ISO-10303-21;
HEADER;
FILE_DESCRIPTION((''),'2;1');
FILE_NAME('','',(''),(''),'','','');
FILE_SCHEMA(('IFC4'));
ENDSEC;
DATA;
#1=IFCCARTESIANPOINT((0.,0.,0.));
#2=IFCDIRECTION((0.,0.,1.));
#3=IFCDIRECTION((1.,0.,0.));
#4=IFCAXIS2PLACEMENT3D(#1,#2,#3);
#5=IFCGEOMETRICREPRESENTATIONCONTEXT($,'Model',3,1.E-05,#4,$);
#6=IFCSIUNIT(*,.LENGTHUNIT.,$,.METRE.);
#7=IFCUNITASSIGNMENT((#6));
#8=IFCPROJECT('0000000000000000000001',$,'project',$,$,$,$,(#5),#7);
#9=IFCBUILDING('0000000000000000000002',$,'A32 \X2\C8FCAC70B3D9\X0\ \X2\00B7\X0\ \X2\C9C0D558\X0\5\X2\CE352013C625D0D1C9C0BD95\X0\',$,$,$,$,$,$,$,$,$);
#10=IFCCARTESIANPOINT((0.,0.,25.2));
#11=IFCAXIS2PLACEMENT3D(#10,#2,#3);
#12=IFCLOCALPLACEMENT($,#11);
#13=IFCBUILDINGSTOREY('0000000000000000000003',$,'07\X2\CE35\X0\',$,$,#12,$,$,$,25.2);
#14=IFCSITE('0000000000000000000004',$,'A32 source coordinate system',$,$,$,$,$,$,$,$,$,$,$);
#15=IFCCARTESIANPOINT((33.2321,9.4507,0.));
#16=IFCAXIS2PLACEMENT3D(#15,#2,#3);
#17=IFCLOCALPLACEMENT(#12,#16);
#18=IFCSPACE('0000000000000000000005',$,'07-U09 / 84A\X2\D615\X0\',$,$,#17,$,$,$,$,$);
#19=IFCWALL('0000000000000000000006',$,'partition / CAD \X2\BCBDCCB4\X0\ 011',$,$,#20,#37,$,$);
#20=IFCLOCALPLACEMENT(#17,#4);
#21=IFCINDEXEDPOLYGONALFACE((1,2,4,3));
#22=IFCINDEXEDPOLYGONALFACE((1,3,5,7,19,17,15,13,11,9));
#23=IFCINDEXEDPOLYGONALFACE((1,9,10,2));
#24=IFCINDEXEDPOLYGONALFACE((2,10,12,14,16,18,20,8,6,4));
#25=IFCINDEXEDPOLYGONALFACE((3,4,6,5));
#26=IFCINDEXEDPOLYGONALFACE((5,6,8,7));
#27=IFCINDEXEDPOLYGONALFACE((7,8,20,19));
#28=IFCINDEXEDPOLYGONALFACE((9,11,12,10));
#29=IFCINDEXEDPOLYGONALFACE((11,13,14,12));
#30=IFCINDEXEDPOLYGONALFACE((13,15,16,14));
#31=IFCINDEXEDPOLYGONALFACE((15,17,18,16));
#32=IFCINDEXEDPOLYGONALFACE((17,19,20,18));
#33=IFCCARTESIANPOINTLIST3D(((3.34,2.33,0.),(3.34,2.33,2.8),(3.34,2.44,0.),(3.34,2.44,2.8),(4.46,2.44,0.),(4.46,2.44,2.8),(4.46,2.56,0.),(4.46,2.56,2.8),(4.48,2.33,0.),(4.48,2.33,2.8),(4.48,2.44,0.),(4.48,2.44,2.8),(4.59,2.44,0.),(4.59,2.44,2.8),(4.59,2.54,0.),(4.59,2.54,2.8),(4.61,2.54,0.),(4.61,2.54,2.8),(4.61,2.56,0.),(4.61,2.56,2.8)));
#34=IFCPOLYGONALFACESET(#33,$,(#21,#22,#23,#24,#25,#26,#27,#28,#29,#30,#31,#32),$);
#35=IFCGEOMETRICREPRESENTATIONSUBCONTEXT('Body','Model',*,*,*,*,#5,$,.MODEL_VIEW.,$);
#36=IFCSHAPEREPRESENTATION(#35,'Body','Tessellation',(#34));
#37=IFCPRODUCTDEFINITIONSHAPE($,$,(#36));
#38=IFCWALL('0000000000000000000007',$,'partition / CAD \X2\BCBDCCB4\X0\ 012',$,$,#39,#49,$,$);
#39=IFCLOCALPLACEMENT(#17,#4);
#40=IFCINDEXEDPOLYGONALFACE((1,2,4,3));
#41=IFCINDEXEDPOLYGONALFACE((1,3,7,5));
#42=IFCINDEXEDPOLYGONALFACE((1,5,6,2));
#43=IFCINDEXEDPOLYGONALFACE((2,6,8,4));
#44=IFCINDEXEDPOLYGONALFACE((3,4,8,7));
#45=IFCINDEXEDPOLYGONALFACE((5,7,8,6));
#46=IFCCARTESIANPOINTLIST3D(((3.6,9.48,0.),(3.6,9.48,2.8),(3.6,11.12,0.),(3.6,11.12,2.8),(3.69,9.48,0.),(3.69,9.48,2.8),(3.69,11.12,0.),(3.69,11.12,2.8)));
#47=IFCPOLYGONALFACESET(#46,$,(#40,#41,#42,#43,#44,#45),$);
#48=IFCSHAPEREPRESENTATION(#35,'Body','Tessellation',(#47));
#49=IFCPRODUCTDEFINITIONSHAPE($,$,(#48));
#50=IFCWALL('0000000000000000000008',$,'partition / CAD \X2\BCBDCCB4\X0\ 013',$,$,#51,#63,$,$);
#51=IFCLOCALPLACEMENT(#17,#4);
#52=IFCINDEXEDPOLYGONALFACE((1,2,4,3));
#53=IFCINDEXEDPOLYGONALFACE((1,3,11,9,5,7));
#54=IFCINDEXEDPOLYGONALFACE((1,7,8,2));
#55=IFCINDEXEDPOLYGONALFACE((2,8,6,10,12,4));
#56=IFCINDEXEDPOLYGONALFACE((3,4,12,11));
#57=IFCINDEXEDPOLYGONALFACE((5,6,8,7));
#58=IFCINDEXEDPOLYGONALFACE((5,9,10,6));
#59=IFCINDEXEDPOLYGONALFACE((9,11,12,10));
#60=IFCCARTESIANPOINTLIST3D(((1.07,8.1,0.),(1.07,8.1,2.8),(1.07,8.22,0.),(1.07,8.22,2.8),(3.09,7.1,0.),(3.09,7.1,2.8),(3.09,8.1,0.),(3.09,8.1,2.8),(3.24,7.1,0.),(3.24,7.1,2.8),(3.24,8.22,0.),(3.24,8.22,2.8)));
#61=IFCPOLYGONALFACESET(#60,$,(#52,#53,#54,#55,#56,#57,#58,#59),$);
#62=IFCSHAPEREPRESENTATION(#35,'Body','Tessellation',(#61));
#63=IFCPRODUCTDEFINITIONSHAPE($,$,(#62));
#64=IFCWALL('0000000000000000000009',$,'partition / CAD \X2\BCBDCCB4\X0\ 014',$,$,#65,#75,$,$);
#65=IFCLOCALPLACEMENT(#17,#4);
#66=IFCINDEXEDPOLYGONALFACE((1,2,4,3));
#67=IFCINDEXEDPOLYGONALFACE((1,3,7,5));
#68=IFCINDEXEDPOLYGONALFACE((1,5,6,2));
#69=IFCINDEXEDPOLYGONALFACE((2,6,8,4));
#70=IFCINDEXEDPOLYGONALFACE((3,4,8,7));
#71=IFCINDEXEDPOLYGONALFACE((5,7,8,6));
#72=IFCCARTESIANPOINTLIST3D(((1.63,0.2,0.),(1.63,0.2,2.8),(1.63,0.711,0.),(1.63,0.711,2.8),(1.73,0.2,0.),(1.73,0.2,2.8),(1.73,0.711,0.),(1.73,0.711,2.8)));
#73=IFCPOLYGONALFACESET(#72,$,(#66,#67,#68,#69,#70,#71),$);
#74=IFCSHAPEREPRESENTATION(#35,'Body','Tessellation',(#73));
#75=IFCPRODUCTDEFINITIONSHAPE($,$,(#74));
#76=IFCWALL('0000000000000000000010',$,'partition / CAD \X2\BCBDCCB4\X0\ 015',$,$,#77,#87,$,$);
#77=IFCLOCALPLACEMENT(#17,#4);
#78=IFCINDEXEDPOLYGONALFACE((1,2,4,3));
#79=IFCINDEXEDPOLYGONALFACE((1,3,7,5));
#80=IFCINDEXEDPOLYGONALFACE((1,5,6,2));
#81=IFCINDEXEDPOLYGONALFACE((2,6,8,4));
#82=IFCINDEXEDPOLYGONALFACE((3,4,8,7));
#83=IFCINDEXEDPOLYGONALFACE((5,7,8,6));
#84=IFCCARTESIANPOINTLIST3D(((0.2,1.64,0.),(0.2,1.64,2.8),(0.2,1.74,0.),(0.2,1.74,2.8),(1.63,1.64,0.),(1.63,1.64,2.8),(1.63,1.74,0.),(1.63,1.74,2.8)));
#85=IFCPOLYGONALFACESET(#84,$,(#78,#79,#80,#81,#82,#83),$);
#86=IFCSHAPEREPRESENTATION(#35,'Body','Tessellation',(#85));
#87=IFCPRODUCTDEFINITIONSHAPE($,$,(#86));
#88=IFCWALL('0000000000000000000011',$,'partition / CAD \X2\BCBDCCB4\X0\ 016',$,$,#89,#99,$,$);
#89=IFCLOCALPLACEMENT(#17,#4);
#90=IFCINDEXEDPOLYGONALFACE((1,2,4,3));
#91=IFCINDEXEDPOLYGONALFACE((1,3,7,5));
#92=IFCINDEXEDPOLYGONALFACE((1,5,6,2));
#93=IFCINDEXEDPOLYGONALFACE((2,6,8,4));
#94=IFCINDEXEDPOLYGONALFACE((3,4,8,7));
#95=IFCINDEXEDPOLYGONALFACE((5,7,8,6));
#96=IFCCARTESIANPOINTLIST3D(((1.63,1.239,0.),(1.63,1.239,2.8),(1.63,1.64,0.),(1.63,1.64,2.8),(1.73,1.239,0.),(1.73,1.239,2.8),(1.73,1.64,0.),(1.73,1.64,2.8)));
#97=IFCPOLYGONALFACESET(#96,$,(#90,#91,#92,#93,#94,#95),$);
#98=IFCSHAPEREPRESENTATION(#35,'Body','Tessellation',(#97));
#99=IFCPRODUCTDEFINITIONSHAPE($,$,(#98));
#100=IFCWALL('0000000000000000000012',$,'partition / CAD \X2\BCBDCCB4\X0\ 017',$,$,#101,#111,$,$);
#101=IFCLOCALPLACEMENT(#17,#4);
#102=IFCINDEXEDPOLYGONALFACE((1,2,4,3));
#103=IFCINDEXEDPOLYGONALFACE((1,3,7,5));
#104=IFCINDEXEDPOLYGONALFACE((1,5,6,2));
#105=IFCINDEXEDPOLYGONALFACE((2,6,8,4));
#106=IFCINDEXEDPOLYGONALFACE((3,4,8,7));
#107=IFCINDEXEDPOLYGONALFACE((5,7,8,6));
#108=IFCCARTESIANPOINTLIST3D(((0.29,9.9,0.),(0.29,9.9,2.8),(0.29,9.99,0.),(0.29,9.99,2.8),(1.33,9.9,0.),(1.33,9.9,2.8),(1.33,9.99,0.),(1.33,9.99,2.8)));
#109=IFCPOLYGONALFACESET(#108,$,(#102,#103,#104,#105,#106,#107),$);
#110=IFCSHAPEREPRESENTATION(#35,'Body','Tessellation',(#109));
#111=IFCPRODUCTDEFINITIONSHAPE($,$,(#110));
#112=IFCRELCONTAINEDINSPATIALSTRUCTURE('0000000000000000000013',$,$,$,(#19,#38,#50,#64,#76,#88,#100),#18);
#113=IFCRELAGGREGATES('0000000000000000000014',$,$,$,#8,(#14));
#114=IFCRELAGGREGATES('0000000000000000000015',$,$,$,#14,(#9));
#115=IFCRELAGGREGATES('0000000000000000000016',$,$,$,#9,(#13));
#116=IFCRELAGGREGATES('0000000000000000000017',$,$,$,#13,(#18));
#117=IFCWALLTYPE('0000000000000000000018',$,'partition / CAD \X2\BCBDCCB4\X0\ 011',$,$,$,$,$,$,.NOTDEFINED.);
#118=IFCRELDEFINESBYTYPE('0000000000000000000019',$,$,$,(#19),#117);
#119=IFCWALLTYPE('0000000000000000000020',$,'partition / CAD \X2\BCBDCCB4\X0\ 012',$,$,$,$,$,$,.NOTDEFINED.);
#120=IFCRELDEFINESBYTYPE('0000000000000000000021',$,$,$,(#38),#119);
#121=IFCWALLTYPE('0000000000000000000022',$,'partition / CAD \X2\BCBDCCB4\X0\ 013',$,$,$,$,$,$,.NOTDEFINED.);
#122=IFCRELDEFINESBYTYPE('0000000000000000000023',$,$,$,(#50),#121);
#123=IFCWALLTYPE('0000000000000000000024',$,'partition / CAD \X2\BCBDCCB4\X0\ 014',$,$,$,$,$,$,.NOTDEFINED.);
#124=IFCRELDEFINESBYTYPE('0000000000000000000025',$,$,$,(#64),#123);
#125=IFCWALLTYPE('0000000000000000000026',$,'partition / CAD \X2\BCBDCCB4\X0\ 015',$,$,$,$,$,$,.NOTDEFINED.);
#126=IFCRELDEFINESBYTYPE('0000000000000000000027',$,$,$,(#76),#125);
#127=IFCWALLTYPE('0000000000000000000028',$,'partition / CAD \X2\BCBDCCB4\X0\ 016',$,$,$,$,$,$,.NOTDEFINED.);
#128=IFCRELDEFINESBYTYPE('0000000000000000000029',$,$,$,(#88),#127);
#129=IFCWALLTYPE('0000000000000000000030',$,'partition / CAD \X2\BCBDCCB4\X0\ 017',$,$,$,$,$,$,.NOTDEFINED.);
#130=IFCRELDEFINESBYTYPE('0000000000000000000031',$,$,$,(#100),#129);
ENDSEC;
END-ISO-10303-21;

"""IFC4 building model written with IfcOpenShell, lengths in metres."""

from ifc_helpers import new_model, si_unit, frame, origin, origin_with_axes, place, context, subcontext, project, spatial, polyline, outline, extrude, source, transform, mapped, type_object, type_shapes, element, save


model = new_model("IFC4")

# Units and contexts
model_context = context("Model", 3, precision=1e-05, world=origin_with_axes())
body_context = subcontext(model_context, "Body", "Model", "MODEL_VIEW")
ifc_project = project(units=[si_unit("LENGTHUNIT", "METRE")], contexts=[model_context])

# Site, building, storey, space
storey_placement = place(None, frame((0.0, 0.0, 25.2), z_axis=(0.0, 0.0, 1.0), x_axis=(1.0, 0.0, 0.0)))
space_placement = place(storey_placement, frame((33.2321, 9.4507, 0.0), z_axis=(0.0, 0.0, 1.0), x_axis=(1.0, 0.0, 0.0)))
site = spatial("IfcSite", under=ifc_project, Name="A32 source coordinate system")
building = spatial("IfcBuilding", under=site, Name="A32 주거동 · 지하5층–옥탑지붕")
storey = spatial("IfcBuildingStorey", under=building, at=storey_placement, Name="07층", Elevation=25.2)
space = spatial("IfcSpace", under=storey, at=space_placement, Name="07-U09 / 84A형")

# Walls
wall_type_1 = type_object("IfcWallType", Name="partition / CAD 벽체 011", PredefinedType="NOTDEFINED")
shared_shape_1 = source(origin(), body_context, "Body", "SweptSolid", [
    extrude(outline(polyline([(3.34, 2.33), (3.34, 2.44), (4.46, 2.44), (4.46, 2.56), (4.61, 2.56), (4.61, 2.54), (4.59, 2.54), (4.59, 2.44), (4.48, 2.44), (4.48, 2.33), (3.34, 2.33)])), origin(), (0.0, 0.0, 1.0), 2.8),
])
type_shapes(wall_type_1, [shared_shape_1])
wall_1_placement = place(space_placement, origin_with_axes())
element("IfcWall", 1, at=wall_1_placement, inside=space, type_object=wall_type_1, Name="partition / CAD 벽체 011", context=body_context, shape_type="MappedRepresentation", body=[
    mapped(shared_shape_1, transform((0.0, 0.0, 0.0), scale=1.0)),
])
wall_type_2 = type_object("IfcWallType", Name="partition / CAD 벽체 012", PredefinedType="NOTDEFINED")
shared_shape_2 = source(origin(), body_context, "Body", "SweptSolid", [
    extrude(outline(polyline([(3.6, 11.12), (3.69, 11.12), (3.69, 9.48), (3.6, 9.48), (3.6, 11.12)])), origin(), (0.0, 0.0, 1.0), 2.8),
])
type_shapes(wall_type_2, [shared_shape_2])
wall_2_placement = place(space_placement, origin_with_axes())
element("IfcWall", 2, at=wall_2_placement, inside=space, type_object=wall_type_2, Name="partition / CAD 벽체 012", context=body_context, shape_type="MappedRepresentation", body=[
    mapped(shared_shape_2, transform((0.0, 0.0, 0.0), scale=1.0)),
])
wall_type_3 = type_object("IfcWallType", Name="partition / CAD 벽체 013", PredefinedType="NOTDEFINED")
shared_shape_3 = source(origin(), body_context, "Body", "SweptSolid", [
    extrude(outline(polyline([(3.09, 8.1), (1.07, 8.1), (1.07, 8.22), (3.24, 8.22), (3.24, 7.1), (3.09, 7.1), (3.09, 8.1)])), origin(), (0.0, 0.0, 1.0), 2.8),
])
type_shapes(wall_type_3, [shared_shape_3])
wall_3_placement = place(space_placement, origin_with_axes())
element("IfcWall", 3, at=wall_3_placement, inside=space, type_object=wall_type_3, Name="partition / CAD 벽체 013", context=body_context, shape_type="MappedRepresentation", body=[
    mapped(shared_shape_3, transform((0.0, 0.0, 0.0), scale=1.0)),
])
wall_type_4 = type_object("IfcWallType", Name="partition / CAD 벽체 014", PredefinedType="NOTDEFINED")
shared_shape_4 = source(origin(), body_context, "Body", "SweptSolid", [
    extrude(outline(polyline([(1.73, 0.2), (1.63, 0.2), (1.63, 0.711), (1.73, 0.711), (1.73, 0.2)])), origin(), (0.0, 0.0, 1.0), 2.8),
])
type_shapes(wall_type_4, [shared_shape_4])
wall_4_placement = place(space_placement, origin_with_axes())
element("IfcWall", 4, at=wall_4_placement, inside=space, type_object=wall_type_4, Name="partition / CAD 벽체 014", context=body_context, shape_type="MappedRepresentation", body=[
    mapped(shared_shape_4, transform((0.0, 0.0, 0.0), scale=1.0)),
])
wall_type_5 = type_object("IfcWallType", Name="partition / CAD 벽체 015", PredefinedType="NOTDEFINED")
shared_shape_5 = source(origin(), body_context, "Body", "SweptSolid", [
    extrude(outline(polyline([(1.63, 1.74), (1.63, 1.64), (0.2, 1.64), (0.2, 1.74), (1.63, 1.74)])), origin(), (0.0, 0.0, 1.0), 2.8),
])
type_shapes(wall_type_5, [shared_shape_5])
wall_5_placement = place(space_placement, origin_with_axes())
element("IfcWall", 5, at=wall_5_placement, inside=space, type_object=wall_type_5, Name="partition / CAD 벽체 015", context=body_context, shape_type="MappedRepresentation", body=[
    mapped(shared_shape_5, transform((0.0, 0.0, 0.0), scale=1.0)),
])
wall_type_6 = type_object("IfcWallType", Name="partition / CAD 벽체 016", PredefinedType="NOTDEFINED")
shared_shape_6 = source(origin(), body_context, "Body", "SweptSolid", [
    extrude(outline(polyline([(1.73, 1.239), (1.63, 1.239), (1.63, 1.64), (1.73, 1.64), (1.73, 1.239)])), origin(), (0.0, 0.0, 1.0), 2.8),
])
type_shapes(wall_type_6, [shared_shape_6])
wall_6_placement = place(space_placement, origin_with_axes())
element("IfcWall", 6, at=wall_6_placement, inside=space, type_object=wall_type_6, Name="partition / CAD 벽체 016", context=body_context, shape_type="MappedRepresentation", body=[
    mapped(shared_shape_6, transform((0.0, 0.0, 0.0), scale=1.0)),
])
wall_type_7 = type_object("IfcWallType", Name="partition / CAD 벽체 017", PredefinedType="NOTDEFINED")
shared_shape_7 = source(origin(), body_context, "Body", "SweptSolid", [
    extrude(outline(polyline([(1.33, 9.99), (1.33, 9.9), (0.29, 9.9), (0.29, 9.99), (1.33, 9.99)])), origin(), (0.0, 0.0, 1.0), 2.8),
])
type_shapes(wall_type_7, [shared_shape_7])
wall_7_placement = place(space_placement, origin_with_axes())
element("IfcWall", 7, at=wall_7_placement, inside=space, type_object=wall_type_7, Name="partition / CAD 벽체 017", context=body_context, shape_type="MappedRepresentation", body=[
    mapped(shared_shape_7, transform((0.0, 0.0, 0.0), scale=1.0)),
])

save(model, "model.ifc")
